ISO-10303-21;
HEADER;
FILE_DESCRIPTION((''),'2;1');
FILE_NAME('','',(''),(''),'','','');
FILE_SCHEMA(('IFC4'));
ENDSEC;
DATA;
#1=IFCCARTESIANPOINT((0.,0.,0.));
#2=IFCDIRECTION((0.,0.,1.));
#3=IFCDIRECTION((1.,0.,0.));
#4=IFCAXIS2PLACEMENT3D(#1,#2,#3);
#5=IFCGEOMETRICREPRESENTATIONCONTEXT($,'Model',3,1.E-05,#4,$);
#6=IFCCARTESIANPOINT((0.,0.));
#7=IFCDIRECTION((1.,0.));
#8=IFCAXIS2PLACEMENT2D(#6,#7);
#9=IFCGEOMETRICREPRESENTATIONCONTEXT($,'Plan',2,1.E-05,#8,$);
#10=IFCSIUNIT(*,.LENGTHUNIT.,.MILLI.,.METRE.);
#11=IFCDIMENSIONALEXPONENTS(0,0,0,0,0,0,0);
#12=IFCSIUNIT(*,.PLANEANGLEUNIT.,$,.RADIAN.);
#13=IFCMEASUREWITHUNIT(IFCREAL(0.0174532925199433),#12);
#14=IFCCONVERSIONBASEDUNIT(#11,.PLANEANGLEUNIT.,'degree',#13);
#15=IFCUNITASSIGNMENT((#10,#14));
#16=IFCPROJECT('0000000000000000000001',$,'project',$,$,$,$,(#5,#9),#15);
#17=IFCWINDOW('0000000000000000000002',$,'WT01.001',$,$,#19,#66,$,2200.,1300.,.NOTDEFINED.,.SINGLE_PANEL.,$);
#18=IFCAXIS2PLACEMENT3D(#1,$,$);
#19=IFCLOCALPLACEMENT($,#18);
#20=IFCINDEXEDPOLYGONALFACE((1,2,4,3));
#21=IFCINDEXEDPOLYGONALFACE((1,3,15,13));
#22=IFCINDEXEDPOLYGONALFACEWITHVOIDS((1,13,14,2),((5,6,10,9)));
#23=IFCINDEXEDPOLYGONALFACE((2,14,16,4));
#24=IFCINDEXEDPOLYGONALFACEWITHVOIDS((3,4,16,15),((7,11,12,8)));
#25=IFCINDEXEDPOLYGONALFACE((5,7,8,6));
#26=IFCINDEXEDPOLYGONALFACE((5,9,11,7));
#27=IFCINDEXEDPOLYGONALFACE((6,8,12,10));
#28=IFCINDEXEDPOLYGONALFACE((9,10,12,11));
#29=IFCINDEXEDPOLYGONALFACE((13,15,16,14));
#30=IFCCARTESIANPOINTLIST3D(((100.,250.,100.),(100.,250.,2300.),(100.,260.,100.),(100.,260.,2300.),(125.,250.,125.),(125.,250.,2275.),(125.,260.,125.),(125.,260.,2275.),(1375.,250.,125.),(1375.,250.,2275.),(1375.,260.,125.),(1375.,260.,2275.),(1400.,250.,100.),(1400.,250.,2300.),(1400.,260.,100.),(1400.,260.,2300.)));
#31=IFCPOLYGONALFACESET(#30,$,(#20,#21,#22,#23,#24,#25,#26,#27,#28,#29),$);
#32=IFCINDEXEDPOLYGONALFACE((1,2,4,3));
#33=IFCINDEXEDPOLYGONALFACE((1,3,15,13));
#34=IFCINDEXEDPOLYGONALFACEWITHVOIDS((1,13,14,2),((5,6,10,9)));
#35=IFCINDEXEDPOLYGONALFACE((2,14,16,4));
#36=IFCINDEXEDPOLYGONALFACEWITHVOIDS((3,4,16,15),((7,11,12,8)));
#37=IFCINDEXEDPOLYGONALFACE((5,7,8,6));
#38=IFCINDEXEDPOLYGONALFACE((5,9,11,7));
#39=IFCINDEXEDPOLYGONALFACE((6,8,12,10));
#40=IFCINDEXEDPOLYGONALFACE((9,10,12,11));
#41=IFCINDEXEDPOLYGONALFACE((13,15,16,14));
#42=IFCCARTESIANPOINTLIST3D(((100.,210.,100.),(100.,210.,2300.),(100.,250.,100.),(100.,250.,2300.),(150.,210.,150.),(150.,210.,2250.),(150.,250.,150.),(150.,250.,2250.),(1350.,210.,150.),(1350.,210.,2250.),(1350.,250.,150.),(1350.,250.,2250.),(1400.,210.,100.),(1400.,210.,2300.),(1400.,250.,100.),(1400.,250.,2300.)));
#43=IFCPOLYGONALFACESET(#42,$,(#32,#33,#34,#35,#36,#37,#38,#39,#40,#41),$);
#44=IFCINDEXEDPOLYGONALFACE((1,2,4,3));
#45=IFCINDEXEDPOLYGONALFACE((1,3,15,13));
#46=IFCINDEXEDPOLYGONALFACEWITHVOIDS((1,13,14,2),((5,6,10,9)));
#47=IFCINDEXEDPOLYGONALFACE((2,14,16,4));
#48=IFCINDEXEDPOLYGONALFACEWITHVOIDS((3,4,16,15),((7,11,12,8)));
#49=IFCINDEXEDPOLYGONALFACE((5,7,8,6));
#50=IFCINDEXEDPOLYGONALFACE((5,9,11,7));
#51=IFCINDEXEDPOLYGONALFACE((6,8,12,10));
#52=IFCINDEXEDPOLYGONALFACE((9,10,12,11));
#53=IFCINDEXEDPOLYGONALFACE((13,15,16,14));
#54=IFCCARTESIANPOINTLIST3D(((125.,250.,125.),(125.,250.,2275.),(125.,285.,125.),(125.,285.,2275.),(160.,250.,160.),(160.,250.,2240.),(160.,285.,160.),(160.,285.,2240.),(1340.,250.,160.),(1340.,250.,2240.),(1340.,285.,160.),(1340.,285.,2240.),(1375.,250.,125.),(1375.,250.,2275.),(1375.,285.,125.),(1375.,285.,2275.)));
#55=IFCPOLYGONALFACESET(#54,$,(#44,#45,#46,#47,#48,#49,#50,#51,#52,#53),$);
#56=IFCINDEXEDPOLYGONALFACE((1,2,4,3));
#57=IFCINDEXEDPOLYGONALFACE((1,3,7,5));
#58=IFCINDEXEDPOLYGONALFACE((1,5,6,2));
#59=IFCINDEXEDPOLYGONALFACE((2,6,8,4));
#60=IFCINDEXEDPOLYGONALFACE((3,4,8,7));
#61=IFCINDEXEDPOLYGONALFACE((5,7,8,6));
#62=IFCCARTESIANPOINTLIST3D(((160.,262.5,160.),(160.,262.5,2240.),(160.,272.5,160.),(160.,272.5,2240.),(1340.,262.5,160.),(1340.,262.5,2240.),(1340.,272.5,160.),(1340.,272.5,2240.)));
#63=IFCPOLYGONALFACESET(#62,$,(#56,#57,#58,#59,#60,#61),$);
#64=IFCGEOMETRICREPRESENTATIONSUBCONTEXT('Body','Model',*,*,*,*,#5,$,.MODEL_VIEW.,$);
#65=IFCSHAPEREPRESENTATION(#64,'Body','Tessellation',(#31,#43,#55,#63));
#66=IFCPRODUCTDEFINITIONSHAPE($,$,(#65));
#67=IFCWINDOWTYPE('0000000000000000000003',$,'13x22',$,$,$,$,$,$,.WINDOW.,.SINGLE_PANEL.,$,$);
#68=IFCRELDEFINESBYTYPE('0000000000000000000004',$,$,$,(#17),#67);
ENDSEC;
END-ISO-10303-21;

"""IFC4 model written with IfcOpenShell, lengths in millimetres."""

from ifc_helpers import new_model, entity, si_unit, converted_unit, frame, origin_with_axes, origin_2d_with_axis, place, context, subcontext, project, line, indexed_curve, outline, extrude, shape, source, transform, mapped, type_object, type_shapes, element, save


model = new_model("IFC4")

# Units and contexts
model_context = context("Model", 3, precision=1e-05, world=origin_with_axes())
plan_context = context("Plan", 2, precision=1e-05, world=origin_2d_with_axis())
body_context_1 = subcontext(model_context, "Body", "Model", "MODEL_VIEW")
body_context_2 = subcontext(plan_context, "Body", "Plan", "PLAN_VIEW")
ifc_project = project(units=[si_unit("LENGTHUNIT", "METRE", prefix="MILLI"), converted_unit("PLANEANGLEUNIT", "degree", entity("IfcReal", 0.0174532925199433), si_unit("PLANEANGLEUNIT", "RADIAN"), dimensions=[0, 0, 0, 0, 0, 0, 0])], contexts=[model_context, plan_context])

# Window
window_type = type_object("IfcWindowType", Name="13x22", PartitioningType="SINGLE_PANEL", PredefinedType="WINDOW")
shared_shape_1 = source(origin_with_axes(), body_context_1, "Body", "SweptSolid", [
    extrude(outline(indexed_curve([(0.0, 0.0, 0.0), (1300.0, 0.0, 0.0), (1300.0, 0.0, 2200.0), (0.0, 0.0, 2200.0)], segments=[line(1, 2), line(2, 3), line(3, 4), line(4, 1)]), holes=[indexed_curve([(25.0, 0.0, 25.0), (1275.0, 0.0, 25.0), (1275.0, 0.0, 2175.0), (25.0, 0.0, 2175.0)], segments=[line(1, 2), line(2, 3), line(3, 4), line(4, 1)])]), frame((0.0, 200.0, 0.0), z_axis=(0.0, 0.0, 1.0), x_axis=(1.0, 0.0, 0.0)), (0.0, 1.0, 0.0), 10.0),
    extrude(outline(indexed_curve([(0.0, 0.0, 0.0), (1300.0, 0.0, 0.0), (1300.0, 0.0, 2200.0), (0.0, 0.0, 2200.0)], segments=[line(1, 2), line(2, 3), line(3, 4), line(4, 1)]), holes=[indexed_curve([(50.0, 0.0, 50.0), (1250.0, 0.0, 50.0), (1250.0, 0.0, 2150.0), (50.0, 0.0, 2150.0)], segments=[line(1, 2), line(2, 3), line(3, 4), line(4, 1)])]), frame((0.0, 160.0, 0.0), z_axis=(0.0, 0.0, 1.0), x_axis=(1.0, 0.0, 0.0)), (0.0, 1.0, 0.0), 40.0),
    extrude(outline(indexed_curve([(0.0, 0.0, 0.0), (1250.0, 0.0, 0.0), (1250.0, 0.0, 2150.0), (0.0, 0.0, 2150.0)], segments=[line(1, 2), line(2, 3), line(3, 4), line(4, 1)]), holes=[indexed_curve([(35.0, 0.0, 35.0), (1215.0, 0.0, 35.0), (1215.0, 0.0, 2115.0), (35.0, 0.0, 2115.0)], segments=[line(1, 2), line(2, 3), line(3, 4), line(4, 1)])]), frame((25.0, 200.0, 25.0), z_axis=(0.0, 0.0, 1.0), x_axis=(1.0, 0.0, 0.0)), (0.0, 1.0, 0.0), 35.0),
    extrude(outline(indexed_curve([(35.0, 0.0, 35.0), (1215.0, 0.0, 35.0), (1215.0, 0.0, 2115.0), (35.0, 0.0, 2115.0)], segments=[line(1, 2), line(2, 3), line(3, 4), line(4, 1)])), frame((25.0, 212.5, 25.0), z_axis=(0.0, 0.0, 1.0), x_axis=(1.0, 0.0, 0.0)), (0.0, 1.0, 0.0), 10.0),
])
shared_shape_2 = source(origin_with_axes(), body_context_2, "Body", "Curve2D", [
    entity("IfcIndexedPolyCurve", entity("IfcCartesianPointList2D", [[50.0, 160.0], [1250.0, 160.0]]), [entity("IfcLineIndex", [1, 2])]),
    entity("IfcIndexedPolyCurve", entity("IfcCartesianPointList2D", [[0.0, 210.0], [25.0, 210.0], [25.0, 200.0], [50.0, 200.0], [50.0, 160.0], [0.0, 160.0]]), [entity("IfcLineIndex", [1, 2]), entity("IfcLineIndex", [2, 3]), entity("IfcLineIndex", [3, 4]), entity("IfcLineIndex", [4, 5]), entity("IfcLineIndex", [5, 6]), entity("IfcLineIndex", [6, 1])]),
    entity("IfcIndexedPolyCurve", entity("IfcCartesianPointList2D", [[1300.0, 210.0], [1275.0, 210.0], [1275.0, 200.0], [1250.0, 200.0], [1250.0, 160.0], [1300.0, 160.0]]), [entity("IfcLineIndex", [1, 2]), entity("IfcLineIndex", [2, 3]), entity("IfcLineIndex", [3, 4]), entity("IfcLineIndex", [4, 5]), entity("IfcLineIndex", [5, 6]), entity("IfcLineIndex", [6, 1])]),
    entity("IfcIndexedPolyCurve", entity("IfcCartesianPointList2D", [[25.0, 200.0], [60.0, 200.0], [60.0, 235.0], [25.0, 235.0]]), [entity("IfcLineIndex", [1, 2]), entity("IfcLineIndex", [2, 3]), entity("IfcLineIndex", [3, 4]), entity("IfcLineIndex", [4, 1])]),
    entity("IfcIndexedPolyCurve", entity("IfcCartesianPointList2D", [[1275.0, 200.0], [1240.0, 200.0], [1240.0, 235.0], [1275.0, 235.0]]), [entity("IfcLineIndex", [1, 2]), entity("IfcLineIndex", [2, 3]), entity("IfcLineIndex", [3, 4]), entity("IfcLineIndex", [4, 1])]),
    entity("IfcIndexedPolyCurve", entity("IfcCartesianPointList2D", [[60.0, 200.0], [1240.0, 200.0]]), [entity("IfcLineIndex", [1, 2])]),
    entity("IfcIndexedPolyCurve", entity("IfcCartesianPointList2D", [[60.0, 235.0], [1240.0, 235.0]]), [entity("IfcLineIndex", [1, 2])]),
    entity("IfcIndexedPolyCurve", entity("IfcCartesianPointList2D", [[60.0, 217.5], [1240.0, 217.5]]), [entity("IfcLineIndex", [1, 2])]),
])
type_shapes(window_type, [shared_shape_1, shared_shape_2])
placement_1 = place(None, origin_with_axes())
placement_2 = place(placement_1, origin_with_axes())
placement_3 = place(placement_2, origin_with_axes())
placement_4 = place(placement_3, frame((-304.3, 0.0, 0.0), z_axis=(0.0, 0.0, 1.0), x_axis=(1.0, 0.0, 0.0)))
placement_5 = place(placement_4, frame((404.3, 50.0, 100.0), z_axis=(0.0, 0.0, 1.0), x_axis=(1.0, 0.0, 0.0)))
window_placement = place(placement_5, origin_with_axes())
element("IfcWindow", 1, at=window_placement, type_object=window_type, Name="WT01.001", OverallHeight=2200.0, OverallWidth=1300.0, PartitioningType="SINGLE_PANEL", PredefinedType="NOTDEFINED", shapes=[
    shape(body_context_1, "Body", "MappedRepresentation", [mapped(shared_shape_1, transform((0.0, 0.0, 0.0), x_axis=(1.0, 0.0, 0.0), y_axis=(0.0, 1.0, 0.0), z_axis=(0.0, 0.0, 1.0), scale=1.0))]),
    shape(body_context_2, "Body", "MappedRepresentation", [mapped(shared_shape_2, transform((0.0, 0.0, 0.0), x_axis=(1.0, 0.0, 0.0), y_axis=(0.0, 1.0, 0.0), z_axis=(0.0, 0.0, 1.0), scale=1.0))]),
])

save(model, "model.ifc")
